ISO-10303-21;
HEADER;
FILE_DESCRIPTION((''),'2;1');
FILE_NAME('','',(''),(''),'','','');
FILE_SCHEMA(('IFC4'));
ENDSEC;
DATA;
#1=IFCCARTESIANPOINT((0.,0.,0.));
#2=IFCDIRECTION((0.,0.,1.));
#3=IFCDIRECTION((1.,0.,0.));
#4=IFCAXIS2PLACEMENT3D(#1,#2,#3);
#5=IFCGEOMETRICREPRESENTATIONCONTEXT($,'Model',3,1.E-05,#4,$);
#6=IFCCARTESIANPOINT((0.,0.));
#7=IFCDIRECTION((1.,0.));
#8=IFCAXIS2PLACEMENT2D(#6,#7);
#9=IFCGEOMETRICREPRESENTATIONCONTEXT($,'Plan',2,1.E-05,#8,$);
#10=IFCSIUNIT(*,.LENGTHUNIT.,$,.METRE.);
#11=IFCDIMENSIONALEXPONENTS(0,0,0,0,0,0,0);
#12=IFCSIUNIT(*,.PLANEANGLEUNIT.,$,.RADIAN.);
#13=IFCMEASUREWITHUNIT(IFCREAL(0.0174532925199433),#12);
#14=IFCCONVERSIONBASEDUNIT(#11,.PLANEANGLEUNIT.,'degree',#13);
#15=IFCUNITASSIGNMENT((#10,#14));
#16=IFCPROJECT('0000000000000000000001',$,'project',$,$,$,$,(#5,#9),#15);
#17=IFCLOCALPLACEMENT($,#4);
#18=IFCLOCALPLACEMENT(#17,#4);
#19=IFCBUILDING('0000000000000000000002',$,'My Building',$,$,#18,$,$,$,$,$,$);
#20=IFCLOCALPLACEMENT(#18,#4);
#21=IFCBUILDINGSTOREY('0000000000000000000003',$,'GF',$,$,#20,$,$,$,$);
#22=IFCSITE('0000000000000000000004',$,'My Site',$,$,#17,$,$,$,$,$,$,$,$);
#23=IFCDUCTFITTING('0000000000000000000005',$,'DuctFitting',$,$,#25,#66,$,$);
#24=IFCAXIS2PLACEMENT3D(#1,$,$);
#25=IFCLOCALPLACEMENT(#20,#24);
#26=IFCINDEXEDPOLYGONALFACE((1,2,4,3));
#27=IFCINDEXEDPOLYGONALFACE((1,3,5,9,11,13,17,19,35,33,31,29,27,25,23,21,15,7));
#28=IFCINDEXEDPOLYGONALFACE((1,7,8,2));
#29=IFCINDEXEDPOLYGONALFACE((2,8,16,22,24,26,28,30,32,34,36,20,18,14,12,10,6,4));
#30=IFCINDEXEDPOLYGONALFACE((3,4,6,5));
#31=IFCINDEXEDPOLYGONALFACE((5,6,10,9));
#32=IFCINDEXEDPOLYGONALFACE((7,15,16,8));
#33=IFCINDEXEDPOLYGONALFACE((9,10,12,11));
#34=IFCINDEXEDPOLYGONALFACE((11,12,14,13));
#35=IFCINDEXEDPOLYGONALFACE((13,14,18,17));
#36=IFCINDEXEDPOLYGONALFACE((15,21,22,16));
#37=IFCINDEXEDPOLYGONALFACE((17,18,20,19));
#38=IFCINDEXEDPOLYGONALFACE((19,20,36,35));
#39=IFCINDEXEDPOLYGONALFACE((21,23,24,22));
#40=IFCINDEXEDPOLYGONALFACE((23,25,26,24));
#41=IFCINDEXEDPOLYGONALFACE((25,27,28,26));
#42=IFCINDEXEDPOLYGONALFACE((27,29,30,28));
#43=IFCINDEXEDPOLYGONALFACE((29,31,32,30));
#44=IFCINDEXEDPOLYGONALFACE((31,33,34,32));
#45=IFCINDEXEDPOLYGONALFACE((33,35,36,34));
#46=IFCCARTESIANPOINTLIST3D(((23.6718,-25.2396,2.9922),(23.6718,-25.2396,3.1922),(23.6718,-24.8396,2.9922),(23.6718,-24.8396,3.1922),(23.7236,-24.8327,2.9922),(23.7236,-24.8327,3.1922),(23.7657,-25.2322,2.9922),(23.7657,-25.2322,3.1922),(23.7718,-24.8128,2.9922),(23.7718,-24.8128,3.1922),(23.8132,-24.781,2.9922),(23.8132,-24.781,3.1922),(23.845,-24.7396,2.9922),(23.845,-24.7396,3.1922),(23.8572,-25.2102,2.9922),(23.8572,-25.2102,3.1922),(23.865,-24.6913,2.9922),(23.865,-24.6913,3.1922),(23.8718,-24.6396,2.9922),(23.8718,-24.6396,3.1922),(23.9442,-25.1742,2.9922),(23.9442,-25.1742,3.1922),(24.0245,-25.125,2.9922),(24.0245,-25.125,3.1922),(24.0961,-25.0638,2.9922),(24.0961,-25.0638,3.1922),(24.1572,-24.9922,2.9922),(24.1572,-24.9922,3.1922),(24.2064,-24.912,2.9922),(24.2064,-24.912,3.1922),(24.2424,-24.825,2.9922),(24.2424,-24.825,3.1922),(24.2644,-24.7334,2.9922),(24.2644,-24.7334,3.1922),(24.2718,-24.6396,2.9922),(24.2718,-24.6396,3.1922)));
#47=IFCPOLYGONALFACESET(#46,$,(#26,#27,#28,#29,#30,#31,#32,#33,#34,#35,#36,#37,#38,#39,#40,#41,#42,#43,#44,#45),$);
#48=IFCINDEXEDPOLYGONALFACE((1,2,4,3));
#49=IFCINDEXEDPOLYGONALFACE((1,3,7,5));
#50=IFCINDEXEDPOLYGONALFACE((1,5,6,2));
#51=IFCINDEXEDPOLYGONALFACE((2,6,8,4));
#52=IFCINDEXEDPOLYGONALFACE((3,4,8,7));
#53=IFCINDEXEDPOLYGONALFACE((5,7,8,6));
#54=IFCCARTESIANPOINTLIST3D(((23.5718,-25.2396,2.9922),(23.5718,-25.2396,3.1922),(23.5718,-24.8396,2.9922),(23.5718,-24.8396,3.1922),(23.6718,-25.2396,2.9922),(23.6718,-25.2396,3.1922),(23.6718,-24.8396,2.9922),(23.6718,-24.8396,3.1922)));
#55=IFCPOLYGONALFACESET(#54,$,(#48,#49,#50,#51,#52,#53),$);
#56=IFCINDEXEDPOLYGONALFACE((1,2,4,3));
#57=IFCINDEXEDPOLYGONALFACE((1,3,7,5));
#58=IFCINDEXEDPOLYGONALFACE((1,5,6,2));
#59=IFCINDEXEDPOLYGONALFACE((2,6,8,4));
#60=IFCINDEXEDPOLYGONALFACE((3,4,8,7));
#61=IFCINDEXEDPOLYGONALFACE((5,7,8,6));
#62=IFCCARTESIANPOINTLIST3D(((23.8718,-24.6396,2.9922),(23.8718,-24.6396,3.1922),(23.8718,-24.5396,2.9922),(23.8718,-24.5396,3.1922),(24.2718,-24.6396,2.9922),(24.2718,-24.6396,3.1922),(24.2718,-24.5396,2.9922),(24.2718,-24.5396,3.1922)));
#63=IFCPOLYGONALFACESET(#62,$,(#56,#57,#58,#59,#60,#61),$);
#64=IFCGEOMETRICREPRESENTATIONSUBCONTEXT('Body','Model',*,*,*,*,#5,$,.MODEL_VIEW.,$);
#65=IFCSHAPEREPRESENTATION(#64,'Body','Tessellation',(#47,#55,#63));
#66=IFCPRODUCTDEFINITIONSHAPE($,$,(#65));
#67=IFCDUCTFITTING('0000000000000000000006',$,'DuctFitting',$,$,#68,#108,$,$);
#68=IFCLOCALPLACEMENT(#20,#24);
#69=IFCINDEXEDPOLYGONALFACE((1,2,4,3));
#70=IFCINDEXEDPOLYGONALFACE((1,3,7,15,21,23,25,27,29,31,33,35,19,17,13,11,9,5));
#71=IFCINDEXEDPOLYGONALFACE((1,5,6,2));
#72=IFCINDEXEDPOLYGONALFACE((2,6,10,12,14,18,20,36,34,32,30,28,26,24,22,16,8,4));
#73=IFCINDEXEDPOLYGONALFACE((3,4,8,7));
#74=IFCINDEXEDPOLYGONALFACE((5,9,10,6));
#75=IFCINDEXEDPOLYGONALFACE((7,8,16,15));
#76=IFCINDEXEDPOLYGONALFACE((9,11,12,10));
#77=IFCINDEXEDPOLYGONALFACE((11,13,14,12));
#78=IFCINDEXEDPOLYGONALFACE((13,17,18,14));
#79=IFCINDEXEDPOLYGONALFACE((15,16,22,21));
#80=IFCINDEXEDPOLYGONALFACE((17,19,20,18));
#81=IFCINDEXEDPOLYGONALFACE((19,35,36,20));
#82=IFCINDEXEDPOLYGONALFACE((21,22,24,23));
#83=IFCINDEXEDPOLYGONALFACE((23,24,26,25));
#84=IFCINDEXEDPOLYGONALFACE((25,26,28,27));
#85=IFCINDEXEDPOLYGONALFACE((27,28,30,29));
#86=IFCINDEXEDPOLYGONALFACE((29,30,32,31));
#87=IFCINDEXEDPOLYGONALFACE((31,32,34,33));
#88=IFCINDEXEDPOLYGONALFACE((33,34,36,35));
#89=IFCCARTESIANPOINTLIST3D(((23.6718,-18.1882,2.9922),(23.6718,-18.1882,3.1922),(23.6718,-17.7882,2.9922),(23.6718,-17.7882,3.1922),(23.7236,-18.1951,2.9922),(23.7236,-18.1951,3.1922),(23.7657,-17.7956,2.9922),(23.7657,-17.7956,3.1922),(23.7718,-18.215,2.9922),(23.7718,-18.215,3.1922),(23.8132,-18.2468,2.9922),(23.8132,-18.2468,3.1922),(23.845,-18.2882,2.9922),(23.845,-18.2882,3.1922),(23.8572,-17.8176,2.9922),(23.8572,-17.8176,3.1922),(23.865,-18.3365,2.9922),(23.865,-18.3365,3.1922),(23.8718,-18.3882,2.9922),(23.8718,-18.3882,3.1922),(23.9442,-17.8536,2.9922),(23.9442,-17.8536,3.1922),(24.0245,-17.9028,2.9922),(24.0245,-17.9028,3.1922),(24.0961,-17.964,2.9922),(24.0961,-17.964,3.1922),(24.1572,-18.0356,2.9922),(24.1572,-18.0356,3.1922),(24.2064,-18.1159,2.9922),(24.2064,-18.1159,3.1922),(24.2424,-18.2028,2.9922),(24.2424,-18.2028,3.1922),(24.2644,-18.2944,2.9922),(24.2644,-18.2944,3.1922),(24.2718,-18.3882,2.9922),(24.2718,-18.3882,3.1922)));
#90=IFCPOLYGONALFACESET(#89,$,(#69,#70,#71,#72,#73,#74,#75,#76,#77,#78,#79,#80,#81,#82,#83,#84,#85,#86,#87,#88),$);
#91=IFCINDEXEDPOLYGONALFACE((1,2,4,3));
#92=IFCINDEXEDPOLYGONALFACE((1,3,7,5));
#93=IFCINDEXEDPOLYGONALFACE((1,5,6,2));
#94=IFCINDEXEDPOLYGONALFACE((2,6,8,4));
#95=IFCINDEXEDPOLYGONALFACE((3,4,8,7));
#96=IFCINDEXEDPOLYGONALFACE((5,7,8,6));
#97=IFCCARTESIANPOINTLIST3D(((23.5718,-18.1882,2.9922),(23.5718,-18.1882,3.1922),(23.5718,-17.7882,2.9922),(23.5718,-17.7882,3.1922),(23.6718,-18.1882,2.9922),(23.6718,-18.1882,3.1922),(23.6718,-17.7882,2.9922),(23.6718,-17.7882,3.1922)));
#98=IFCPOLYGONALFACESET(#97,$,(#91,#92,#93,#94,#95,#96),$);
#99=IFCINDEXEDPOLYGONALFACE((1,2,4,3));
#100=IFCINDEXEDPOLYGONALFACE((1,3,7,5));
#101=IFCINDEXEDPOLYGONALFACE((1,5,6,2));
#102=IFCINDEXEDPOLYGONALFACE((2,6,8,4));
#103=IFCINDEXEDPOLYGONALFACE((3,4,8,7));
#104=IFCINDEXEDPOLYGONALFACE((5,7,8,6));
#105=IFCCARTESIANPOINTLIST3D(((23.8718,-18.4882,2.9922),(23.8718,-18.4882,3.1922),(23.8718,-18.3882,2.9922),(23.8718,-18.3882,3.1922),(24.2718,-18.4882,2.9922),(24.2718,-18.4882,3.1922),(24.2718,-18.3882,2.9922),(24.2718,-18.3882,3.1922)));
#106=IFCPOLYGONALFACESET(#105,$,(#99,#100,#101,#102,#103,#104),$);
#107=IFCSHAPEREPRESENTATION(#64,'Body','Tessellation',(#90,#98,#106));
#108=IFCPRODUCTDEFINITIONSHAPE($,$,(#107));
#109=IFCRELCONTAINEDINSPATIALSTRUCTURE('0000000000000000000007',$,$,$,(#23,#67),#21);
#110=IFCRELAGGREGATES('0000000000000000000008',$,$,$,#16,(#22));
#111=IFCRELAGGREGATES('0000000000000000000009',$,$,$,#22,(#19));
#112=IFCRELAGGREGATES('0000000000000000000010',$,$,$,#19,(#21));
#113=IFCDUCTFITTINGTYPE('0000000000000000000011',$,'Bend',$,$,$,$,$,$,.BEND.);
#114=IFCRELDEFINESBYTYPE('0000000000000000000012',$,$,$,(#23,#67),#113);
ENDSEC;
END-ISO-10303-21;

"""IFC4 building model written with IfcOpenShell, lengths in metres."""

from ifc_helpers import new_model, entity, si_unit, converted_unit, frame, origin_with_axes, origin_2d_with_axis, place, context, subcontext, project, spatial, line, arc, indexed_curve, rectangle, outline, extrude, source, transform, mapped, type_object, type_shapes, element, save


model = new_model("IFC4")

# Units and contexts
model_context = context("Model", 3, precision=1e-05, world=origin_with_axes())
plan_context = context("Plan", 2, precision=1e-05, world=origin_2d_with_axis())
body_context_1 = subcontext(model_context, "Body", "Model", "MODEL_VIEW")
ifc_project = project(units=[si_unit("LENGTHUNIT", "METRE"), converted_unit("PLANEANGLEUNIT", "degree", entity("IfcReal", 0.0174532925199433), si_unit("PLANEANGLEUNIT", "RADIAN"), dimensions=[0, 0, 0, 0, 0, 0, 0])], contexts=[model_context, plan_context])

# Site, building, storey
site_placement = place(None, origin_with_axes())
site = spatial("IfcSite", under=ifc_project, at=site_placement, Name="My Site")
building_placement = place(site_placement, origin_with_axes())
building = spatial("IfcBuilding", under=site, at=building_placement, Name="My Building")
storey_placement = place(building_placement, origin_with_axes())
storey = spatial("IfcBuildingStorey", under=building, at=storey_placement, Name="GF")

# Duct fittings
duct_fitting_type = type_object("IfcDuctFittingType", Name="Bend", PredefinedType="BEND")
shared_shape_1 = source(origin_with_axes(), body_context_1, "Body", "SweptSolid", [
    extrude(outline(indexed_curve([(0.2, 0.0), (0.2586, -0.1414), (0.4, -0.2), (0.4, -0.6), (-0.0243, -0.4243), (-0.2, 0.0)], segments=[arc(1, 2, 3), line(3, 4), arc(4, 5, 6), line(6, 1)])), frame((0.0, -0.1, -0.1), z_axis=(0.0, -1.0, 0.0), x_axis=(1.0, 0.0, 0.0)), (0.0, 0.0, -1.0), 0.2),
    extrude(rectangle(XDim=0.4, YDim=0.2), origin_with_axes(), (0.0, 0.0, -1.0), 0.1),
    extrude(rectangle(XDim=0.4, YDim=0.2), frame((0.4, 0.0, -0.5), z_axis=(1.0, 0.0, 0.0), x_axis=(0.0, 0.0, 1.0)), (0.0, 0.0, 1.0), 0.1),
])
type_shapes(duct_fitting_type, [shared_shape_1])
for number, where, z_axis, x_axis, name in (
    (1, (23.5718, -25.0396, 3.0922), (-1.0, 0.0, 0.0), (0.0, 1.0, 0.0), "DuctFitting"),
    (2, (23.5718, -17.9882, 3.0922), (-1.0, 0.0, 0.0), (0.0, -1.0, 0.0), "DuctFitting"),
):
    element("IfcDuctFitting", number, at=place(storey_placement, frame(where, z_axis=z_axis, x_axis=x_axis)), inside=storey, type_object=duct_fitting_type, Name=name, context=body_context_1, shape_type="MappedRepresentation", body=[
        mapped(shared_shape_1, transform((0.0, 0.0, 0.0), x_axis=(1.0, 0.0, 0.0), y_axis=(0.0, 1.0, 0.0), z_axis=(0.0, 0.0, 1.0), scale=1.0)),
    ])

save(model, "model.ifc")
